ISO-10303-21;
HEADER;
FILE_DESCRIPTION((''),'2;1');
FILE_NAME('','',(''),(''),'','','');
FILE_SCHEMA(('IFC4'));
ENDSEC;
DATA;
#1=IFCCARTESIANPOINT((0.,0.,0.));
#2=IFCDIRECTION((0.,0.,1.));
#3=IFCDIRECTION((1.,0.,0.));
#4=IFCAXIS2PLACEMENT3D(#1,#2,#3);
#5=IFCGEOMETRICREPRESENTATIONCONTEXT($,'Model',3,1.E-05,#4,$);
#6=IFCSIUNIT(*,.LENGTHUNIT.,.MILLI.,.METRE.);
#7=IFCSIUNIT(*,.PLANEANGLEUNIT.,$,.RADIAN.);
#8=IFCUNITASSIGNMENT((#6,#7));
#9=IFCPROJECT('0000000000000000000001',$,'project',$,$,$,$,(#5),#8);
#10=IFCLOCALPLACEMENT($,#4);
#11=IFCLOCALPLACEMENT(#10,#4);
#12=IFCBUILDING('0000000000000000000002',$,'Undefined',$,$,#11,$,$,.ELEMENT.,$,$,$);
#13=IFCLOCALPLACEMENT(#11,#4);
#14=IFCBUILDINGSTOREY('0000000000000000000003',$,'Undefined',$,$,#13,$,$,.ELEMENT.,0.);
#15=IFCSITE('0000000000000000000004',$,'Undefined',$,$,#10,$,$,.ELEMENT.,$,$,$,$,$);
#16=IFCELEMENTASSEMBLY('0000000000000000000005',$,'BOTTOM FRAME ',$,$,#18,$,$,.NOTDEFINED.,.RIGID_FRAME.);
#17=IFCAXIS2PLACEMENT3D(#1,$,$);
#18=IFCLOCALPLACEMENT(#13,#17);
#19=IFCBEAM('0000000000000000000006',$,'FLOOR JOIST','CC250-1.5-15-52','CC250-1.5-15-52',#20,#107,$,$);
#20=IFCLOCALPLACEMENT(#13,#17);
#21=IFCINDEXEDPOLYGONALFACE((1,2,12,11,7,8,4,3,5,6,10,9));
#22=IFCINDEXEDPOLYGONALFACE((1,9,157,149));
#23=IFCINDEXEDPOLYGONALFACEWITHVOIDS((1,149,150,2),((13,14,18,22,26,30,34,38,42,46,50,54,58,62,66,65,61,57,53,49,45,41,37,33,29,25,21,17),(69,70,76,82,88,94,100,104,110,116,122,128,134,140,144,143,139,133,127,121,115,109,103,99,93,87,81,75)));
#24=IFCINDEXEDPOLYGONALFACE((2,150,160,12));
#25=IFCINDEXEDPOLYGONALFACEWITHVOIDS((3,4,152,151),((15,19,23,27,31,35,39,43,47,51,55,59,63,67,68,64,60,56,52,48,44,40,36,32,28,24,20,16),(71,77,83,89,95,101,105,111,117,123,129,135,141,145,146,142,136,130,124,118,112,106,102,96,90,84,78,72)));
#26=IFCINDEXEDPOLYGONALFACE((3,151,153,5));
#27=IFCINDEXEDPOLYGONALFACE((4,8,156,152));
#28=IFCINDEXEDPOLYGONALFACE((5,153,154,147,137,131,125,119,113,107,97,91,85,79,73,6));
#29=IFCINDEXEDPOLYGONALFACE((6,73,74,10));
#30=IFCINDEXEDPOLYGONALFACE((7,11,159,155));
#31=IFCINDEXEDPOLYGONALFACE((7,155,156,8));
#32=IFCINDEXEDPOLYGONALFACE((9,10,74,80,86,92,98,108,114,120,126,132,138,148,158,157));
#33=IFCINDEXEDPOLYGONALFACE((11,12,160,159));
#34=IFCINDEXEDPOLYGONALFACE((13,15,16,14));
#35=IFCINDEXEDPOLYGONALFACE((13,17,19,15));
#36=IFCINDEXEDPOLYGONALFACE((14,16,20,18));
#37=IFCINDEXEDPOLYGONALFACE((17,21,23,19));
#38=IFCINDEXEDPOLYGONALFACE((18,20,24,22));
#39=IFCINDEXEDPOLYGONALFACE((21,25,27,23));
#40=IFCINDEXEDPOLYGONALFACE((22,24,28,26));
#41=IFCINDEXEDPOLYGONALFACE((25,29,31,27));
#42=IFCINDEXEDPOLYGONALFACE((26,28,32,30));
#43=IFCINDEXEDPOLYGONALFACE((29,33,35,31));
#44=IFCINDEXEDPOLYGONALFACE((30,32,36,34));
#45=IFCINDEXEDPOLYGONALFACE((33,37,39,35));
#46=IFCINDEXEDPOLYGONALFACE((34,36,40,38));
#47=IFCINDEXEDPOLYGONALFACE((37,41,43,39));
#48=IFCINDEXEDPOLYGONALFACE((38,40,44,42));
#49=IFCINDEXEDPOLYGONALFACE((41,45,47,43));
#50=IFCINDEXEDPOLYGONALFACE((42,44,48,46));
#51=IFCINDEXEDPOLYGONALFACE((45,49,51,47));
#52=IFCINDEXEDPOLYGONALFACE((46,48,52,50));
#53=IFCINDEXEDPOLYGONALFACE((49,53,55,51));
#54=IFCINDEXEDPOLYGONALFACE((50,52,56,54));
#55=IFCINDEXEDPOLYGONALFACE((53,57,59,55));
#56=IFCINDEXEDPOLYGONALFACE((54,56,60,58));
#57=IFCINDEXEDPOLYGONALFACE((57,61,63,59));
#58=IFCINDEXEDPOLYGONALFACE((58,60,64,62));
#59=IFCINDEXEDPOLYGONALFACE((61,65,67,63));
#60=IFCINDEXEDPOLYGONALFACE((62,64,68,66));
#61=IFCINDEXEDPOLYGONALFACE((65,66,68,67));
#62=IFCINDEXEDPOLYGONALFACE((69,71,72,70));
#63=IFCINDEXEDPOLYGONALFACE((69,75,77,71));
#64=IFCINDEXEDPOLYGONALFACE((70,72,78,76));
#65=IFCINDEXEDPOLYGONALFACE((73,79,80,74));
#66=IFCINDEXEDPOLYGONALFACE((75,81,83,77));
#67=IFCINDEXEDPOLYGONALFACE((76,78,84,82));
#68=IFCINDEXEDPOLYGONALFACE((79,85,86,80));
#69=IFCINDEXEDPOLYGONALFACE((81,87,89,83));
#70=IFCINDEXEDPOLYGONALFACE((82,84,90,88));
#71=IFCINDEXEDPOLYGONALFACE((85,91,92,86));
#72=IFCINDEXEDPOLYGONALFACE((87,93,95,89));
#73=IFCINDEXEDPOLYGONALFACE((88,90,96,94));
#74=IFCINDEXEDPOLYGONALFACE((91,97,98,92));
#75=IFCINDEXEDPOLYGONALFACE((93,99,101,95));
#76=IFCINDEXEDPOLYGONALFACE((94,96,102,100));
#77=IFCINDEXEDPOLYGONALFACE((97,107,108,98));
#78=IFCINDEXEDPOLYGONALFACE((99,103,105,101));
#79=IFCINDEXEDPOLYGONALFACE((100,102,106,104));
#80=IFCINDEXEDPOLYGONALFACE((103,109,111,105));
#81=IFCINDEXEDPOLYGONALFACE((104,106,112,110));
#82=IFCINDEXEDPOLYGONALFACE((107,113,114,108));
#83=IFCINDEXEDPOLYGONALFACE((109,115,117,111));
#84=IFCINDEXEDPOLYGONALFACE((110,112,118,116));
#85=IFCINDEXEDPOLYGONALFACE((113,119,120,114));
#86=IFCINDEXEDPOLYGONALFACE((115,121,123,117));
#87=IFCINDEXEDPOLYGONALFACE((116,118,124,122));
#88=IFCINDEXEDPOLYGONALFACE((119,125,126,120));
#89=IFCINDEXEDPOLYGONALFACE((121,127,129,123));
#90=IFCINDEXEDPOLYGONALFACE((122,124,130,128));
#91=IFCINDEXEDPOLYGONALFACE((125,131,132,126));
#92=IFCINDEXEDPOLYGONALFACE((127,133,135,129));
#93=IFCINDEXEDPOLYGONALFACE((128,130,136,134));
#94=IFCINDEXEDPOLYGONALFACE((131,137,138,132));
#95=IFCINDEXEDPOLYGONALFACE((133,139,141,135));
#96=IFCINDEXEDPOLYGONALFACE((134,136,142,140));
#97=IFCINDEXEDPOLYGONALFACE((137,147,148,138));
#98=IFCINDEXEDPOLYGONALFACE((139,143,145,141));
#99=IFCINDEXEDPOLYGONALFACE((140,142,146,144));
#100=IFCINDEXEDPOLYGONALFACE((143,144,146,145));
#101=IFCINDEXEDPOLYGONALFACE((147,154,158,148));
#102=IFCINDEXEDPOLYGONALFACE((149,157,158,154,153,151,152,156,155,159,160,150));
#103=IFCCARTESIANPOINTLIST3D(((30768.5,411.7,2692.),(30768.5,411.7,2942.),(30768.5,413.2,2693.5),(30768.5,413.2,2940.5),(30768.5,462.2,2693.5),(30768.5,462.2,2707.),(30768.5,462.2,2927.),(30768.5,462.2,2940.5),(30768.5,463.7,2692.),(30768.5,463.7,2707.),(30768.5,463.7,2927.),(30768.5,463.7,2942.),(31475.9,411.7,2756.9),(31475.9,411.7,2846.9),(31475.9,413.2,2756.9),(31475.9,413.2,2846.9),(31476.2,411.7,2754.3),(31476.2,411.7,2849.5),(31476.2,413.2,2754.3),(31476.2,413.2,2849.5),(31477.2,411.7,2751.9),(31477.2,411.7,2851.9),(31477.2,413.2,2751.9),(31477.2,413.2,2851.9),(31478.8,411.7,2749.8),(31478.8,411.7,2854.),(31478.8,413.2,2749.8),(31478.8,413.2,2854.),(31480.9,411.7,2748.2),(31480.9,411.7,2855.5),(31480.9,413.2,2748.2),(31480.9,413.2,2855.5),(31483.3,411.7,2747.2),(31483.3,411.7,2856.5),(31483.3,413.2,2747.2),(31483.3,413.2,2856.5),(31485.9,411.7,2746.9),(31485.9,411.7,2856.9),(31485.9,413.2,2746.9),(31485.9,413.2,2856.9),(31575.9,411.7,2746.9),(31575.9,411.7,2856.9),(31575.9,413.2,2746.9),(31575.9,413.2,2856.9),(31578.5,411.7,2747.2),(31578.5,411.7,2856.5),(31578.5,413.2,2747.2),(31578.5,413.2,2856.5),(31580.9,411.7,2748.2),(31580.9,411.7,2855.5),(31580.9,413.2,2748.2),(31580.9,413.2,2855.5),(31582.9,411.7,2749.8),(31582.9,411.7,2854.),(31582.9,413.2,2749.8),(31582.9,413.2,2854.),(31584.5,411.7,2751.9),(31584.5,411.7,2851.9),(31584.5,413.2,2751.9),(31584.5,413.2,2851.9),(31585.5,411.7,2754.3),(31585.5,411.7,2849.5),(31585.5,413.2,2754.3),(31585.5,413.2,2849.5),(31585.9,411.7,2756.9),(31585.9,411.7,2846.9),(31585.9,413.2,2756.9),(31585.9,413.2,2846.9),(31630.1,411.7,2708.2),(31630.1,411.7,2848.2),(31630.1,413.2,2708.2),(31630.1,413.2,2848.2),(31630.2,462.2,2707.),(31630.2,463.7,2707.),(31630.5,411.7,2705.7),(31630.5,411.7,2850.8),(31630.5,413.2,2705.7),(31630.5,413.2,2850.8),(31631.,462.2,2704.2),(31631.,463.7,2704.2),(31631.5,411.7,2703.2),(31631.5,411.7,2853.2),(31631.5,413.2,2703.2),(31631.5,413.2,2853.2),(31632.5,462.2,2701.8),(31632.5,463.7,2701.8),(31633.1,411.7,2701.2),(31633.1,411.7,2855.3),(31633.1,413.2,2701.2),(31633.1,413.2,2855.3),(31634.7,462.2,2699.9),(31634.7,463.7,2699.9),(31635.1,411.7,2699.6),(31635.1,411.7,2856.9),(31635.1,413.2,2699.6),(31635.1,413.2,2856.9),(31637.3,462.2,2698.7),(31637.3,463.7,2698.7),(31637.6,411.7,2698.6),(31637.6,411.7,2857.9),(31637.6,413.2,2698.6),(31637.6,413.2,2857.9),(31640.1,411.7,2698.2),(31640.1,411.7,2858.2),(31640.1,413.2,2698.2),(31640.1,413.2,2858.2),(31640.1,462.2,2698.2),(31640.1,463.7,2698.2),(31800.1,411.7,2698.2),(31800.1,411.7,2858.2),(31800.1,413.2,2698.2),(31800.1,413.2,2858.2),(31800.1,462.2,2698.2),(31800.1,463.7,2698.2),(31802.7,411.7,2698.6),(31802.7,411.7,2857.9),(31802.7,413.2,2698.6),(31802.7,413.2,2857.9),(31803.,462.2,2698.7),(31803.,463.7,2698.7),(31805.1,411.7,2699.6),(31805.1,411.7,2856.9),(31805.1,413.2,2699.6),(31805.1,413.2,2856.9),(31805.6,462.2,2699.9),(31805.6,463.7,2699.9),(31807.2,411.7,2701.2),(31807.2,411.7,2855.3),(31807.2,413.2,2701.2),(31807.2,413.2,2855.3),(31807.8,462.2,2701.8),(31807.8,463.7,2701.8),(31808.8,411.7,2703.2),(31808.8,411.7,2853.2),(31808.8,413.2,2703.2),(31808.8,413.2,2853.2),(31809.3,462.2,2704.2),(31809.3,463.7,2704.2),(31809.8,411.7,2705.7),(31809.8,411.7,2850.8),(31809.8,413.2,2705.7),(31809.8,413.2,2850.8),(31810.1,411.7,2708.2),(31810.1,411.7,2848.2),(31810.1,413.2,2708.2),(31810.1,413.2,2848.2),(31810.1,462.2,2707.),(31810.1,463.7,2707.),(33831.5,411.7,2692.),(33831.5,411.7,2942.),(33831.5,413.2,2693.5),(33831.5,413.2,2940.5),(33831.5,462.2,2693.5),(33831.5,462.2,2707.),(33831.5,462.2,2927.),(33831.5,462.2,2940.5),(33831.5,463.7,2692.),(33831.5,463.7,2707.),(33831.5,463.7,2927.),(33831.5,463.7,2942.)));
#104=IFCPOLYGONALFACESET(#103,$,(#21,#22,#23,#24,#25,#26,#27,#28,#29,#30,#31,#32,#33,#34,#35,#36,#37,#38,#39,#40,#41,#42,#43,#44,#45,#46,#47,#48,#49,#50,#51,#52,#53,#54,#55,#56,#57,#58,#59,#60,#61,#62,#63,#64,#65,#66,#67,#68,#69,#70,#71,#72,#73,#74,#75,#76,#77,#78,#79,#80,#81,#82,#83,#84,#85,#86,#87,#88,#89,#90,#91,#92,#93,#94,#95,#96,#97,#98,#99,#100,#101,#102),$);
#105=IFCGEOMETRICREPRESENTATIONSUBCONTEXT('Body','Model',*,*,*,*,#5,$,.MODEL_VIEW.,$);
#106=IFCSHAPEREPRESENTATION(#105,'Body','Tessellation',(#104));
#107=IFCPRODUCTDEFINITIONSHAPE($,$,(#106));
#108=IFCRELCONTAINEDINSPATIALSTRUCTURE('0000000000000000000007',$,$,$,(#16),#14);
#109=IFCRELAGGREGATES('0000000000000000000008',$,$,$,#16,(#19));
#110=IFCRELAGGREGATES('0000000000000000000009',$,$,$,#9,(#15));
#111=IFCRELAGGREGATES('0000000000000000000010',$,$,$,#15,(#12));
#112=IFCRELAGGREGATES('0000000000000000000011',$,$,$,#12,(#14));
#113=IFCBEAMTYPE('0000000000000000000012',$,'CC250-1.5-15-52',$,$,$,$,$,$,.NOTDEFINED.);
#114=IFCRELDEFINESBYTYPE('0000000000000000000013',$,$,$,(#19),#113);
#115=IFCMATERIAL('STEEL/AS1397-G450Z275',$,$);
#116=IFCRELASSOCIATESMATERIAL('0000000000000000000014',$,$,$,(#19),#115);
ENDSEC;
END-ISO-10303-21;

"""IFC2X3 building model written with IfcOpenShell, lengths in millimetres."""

from ifc_helpers import new_model, si_unit, frame, frame_2d, origin_with_axes, origin_2d_with_axis, place, context, subcontext, project, spatial, polyline, circle_curve, parameter, trimmed, segment, composite_curve, c_section, outline, extrude, boolean, material, type_object, element, aggregate, save


model = new_model("IFC2X3")

# Units and contexts
model_context = context("Model", 3, precision=1e-05, world=origin_with_axes())
body_context = subcontext(model_context, "Body", "Model", "MODEL_VIEW")
ifc_project = project(units=[si_unit("LENGTHUNIT", "METRE", prefix="MILLI"), si_unit("PLANEANGLEUNIT", "RADIAN")], contexts=[model_context])

# Site, building, storey
site_placement = place(None, origin_with_axes())
site = spatial("IfcSite", under=ifc_project, at=site_placement, Name="Undefined", CompositionType="ELEMENT")
building_placement = place(site_placement, origin_with_axes())
building = spatial("IfcBuilding", under=site, at=building_placement, Name="Undefined", CompositionType="ELEMENT")
storey_placement = place(building_placement, origin_with_axes())
storey = spatial("IfcBuildingStorey", under=building, at=storey_placement, Name="Undefined", CompositionType="ELEMENT", Elevation=0.0)

# Element assembly, beam
assembly_1_placement = place(storey_placement, origin_with_axes())
assembly_1 = element("IfcElementAssembly", 1, at=assembly_1_placement, inside=storey, Name="BOTTOM FRAME ", AssemblyPlace="NOTDEFINED", PredefinedType="RIGID_FRAME")
ifc_material_1 = material(Name="STEEL/AS1397-G450Z275")
beam_type_1 = type_object("IfcBeamType", Name="CC250-1.5-15-52", PredefinedType="NOTDEFINED")
beam_1_placement = place(assembly_1_placement, frame((30768.5, 437.7, 2817.0), z_axis=(0.0, 0.0, -1.0), x_axis=(1.0, 0.0, 0.0)))
beam_1 = element("IfcBeam", 2, at=beam_1_placement, type_object=beam_type_1, material=ifc_material_1, Name="FLOOR JOIST", Description="CC250-1.5-15-52", ObjectType="CC250-1.5-15-52", context=body_context, shape_type="CSG", body=[
    boolean("DIFFERENCE", boolean("DIFFERENCE", extrude(c_section(Depth=250.0, Width=52.0, WallThickness=1.5, Girth=15.0, at=origin_2d_with_axis()), frame((3063.0, 0.0, 0.0), z_axis=(-1.0, 0.0, 0.0), x_axis=(0.0, -1.0, 0.0)), (0.0, 0.0, 1.0), 3063.0), extrude(outline(composite_curve([segment(trimmed(circle_curve(frame_2d((10.0, 10.0), x_axis=(-1.0, 0.0)), 10.0), [parameter(0.0)], [parameter(1.570796)], True, "PARAMETER"), True, "CONTINUOUS"), segment(polyline([(10.0, 0.0), (170.0, 0.0)]), True, "CONTINUOUS"), segment(trimmed(circle_curve(frame_2d((170.0, 10.0), x_axis=(0.0, -1.0)), 10.0), [parameter(0.0)], [parameter(1.570796)], True, "PARAMETER"), True, "CONTINUOUS"), segment(polyline([(180.0, 10.0), (180.0, 150.0)]), True, "CONTINUOUS"), segment(trimmed(circle_curve(frame_2d((170.0, 150.0), x_axis=(1.0, 0.0)), 10.0), [parameter(0.0)], [parameter(1.570796)], True, "PARAMETER"), True, "CONTINUOUS"), segment(polyline([(170.0, 160.0), (10.0, 160.0)]), True, "CONTINUOUS"), segment(trimmed(circle_curve(frame_2d((10.0, 150.0), x_axis=(0.0, 1.0)), 10.0), [parameter(0.0)], [parameter(1.570796)], True, "PARAMETER"), True, "CONTINUOUS"), segment(polyline([(0.0, 150.0), (0.0, 10.0)]), True, "CONTINUOUS")], self_intersect=True)), frame((861.6, 40.5, -41.2), z_axis=(0.0, -1.0, 0.0), x_axis=(1.0, 0.0, 0.0)), (0.0, 0.0, 1.0), 81.0)), extrude(outline(composite_curve([segment(trimmed(circle_curve(frame_2d((10.0, 10.0), x_axis=(-1.0, 0.0)), 10.0), [parameter(0.0)], [parameter(1.570796)], True, "PARAMETER"), True, "CONTINUOUS"), segment(polyline([(10.0, 0.0), (100.0, 0.0)]), True, "CONTINUOUS"), segment(trimmed(circle_curve(frame_2d((100.0, 10.0), x_axis=(0.0, -1.0)), 10.0), [parameter(0.0)], [parameter(1.570796)], True, "PARAMETER"), True, "CONTINUOUS"), segment(polyline([(110.0, 10.0), (110.0, 100.0)]), True, "CONTINUOUS"), segment(trimmed(circle_curve(frame_2d((100.0, 100.0), x_axis=(1.0, 0.0)), 10.0), [parameter(0.0)], [parameter(1.570796)], True, "PARAMETER"), True, "CONTINUOUS"), segment(polyline([(100.0, 110.0), (10.0, 110.0)]), True, "CONTINUOUS"), segment(trimmed(circle_curve(frame_2d((10.0, 100.0), x_axis=(0.0, 1.0)), 10.0), [parameter(0.0)], [parameter(1.570796)], True, "PARAMETER"), True, "CONTINUOUS"), segment(polyline([(0.0, 100.0), (0.0, 10.0)]), True, "CONTINUOUS")], self_intersect=True)), frame((707.4, 40.5, -39.9), z_axis=(0.0, -1.0, 0.0), x_axis=(1.0, 0.0, 0.0)), (0.0, 0.0, 1.0), 81.0)),
])
aggregate(assembly_1, [beam_1])

save(model, "model.ifc")
